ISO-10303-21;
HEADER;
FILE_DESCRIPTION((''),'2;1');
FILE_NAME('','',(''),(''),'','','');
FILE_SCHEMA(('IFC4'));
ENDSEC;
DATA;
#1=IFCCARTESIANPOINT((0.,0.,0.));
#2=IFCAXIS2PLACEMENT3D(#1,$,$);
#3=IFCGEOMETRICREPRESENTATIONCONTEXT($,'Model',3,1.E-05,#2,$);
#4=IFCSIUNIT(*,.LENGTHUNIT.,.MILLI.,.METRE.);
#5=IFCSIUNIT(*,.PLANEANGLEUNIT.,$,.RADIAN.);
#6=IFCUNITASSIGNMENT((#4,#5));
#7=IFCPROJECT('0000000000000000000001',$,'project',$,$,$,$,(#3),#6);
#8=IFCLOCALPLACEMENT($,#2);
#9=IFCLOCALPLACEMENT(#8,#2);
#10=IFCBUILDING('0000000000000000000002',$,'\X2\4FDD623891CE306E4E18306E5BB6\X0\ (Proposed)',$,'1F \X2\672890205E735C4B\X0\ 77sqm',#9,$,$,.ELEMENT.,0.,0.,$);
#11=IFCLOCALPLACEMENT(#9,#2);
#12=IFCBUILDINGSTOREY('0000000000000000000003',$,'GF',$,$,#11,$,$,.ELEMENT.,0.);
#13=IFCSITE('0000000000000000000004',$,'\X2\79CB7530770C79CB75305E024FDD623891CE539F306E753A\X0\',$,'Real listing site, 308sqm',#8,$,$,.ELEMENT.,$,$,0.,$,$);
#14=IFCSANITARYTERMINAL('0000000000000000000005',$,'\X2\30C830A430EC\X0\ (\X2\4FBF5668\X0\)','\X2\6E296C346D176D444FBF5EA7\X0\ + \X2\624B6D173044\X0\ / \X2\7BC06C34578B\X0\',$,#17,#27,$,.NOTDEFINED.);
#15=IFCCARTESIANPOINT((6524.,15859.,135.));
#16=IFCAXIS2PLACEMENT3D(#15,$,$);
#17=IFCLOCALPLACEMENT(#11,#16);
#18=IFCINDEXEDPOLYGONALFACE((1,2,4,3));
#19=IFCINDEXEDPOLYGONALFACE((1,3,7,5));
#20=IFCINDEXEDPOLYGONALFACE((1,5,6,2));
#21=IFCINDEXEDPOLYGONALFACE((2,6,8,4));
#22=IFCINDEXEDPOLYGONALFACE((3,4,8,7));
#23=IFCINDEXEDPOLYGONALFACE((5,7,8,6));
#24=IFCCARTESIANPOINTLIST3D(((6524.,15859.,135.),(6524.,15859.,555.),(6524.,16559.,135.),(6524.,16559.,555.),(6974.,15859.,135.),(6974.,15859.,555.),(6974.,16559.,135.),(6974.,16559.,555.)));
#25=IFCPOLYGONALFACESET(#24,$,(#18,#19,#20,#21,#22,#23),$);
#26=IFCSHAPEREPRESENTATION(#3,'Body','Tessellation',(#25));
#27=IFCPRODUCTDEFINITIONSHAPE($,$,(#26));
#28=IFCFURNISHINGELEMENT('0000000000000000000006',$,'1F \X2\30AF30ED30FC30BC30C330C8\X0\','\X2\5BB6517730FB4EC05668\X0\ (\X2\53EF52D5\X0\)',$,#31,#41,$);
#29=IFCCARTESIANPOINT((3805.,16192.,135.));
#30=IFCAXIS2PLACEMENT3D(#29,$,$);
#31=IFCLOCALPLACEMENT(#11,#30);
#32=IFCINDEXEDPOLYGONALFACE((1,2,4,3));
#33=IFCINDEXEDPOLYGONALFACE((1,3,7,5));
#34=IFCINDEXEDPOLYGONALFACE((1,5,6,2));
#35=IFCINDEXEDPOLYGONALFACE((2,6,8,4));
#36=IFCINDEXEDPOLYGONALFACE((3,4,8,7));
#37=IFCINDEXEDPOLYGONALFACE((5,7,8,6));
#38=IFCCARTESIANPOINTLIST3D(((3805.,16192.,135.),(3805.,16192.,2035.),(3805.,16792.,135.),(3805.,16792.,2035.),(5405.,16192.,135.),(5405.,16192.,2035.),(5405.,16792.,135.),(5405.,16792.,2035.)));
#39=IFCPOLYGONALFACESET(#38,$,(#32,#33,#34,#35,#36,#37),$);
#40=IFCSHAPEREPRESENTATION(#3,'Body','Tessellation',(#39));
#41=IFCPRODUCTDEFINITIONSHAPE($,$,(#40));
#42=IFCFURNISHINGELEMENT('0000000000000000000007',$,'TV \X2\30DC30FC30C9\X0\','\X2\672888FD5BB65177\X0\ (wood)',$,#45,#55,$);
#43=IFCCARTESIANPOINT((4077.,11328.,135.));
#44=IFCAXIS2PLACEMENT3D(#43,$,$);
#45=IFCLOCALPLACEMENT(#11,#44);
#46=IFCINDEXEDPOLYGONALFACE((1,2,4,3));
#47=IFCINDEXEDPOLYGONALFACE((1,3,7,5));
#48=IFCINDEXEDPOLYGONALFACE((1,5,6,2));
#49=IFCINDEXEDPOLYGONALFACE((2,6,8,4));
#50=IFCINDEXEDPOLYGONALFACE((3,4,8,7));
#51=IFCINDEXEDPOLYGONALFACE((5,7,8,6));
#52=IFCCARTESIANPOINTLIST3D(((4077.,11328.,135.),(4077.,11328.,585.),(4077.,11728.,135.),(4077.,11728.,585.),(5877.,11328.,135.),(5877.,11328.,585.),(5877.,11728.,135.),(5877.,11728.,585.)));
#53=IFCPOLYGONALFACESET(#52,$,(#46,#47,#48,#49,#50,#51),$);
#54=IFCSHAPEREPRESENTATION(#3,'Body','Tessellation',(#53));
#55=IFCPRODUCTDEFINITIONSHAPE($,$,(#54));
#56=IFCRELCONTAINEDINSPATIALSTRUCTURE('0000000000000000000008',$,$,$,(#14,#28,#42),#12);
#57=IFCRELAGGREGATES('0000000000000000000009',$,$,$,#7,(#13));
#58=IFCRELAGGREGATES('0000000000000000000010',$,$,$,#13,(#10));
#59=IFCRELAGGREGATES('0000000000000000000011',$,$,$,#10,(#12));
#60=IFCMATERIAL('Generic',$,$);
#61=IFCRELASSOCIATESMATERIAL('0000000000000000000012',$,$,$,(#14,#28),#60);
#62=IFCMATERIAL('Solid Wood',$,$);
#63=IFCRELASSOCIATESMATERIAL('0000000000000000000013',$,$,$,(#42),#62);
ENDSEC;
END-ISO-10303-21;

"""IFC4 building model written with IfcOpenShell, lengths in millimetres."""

from ifc_helpers import new_model, si_unit, frame, frame_2d, origin, place, context, project, spatial, rectangle, extrude, material, element, save


model = new_model("IFC4")

# Units and contexts
model_context = context("Model", 3, precision=1e-05, world=origin())
ifc_project = project(units=[si_unit("LENGTHUNIT", "METRE", prefix="MILLI"), si_unit("PLANEANGLEUNIT", "RADIAN")], contexts=[model_context])

# Site, building, storey
site_placement = place(None, origin())
site = spatial("IfcSite", under=ifc_project, at=site_placement, Name="秋田県秋田市保戸野原の町", ObjectType="Real listing site, 308sqm", CompositionType="ELEMENT", RefElevation=0.0)
building_placement = place(site_placement, origin())
building = spatial("IfcBuilding", under=site, at=building_placement, Name="保戸野の丘の家 (Proposed)", ObjectType="1F 木造平屋 77sqm", CompositionType="ELEMENT", ElevationOfRefHeight=0.0, ElevationOfTerrain=0.0)
storey_placement = place(building_placement, origin())
storey = spatial("IfcBuildingStorey", under=building, at=storey_placement, Name="GF", CompositionType="ELEMENT", Elevation=0.0)

# Shared definitions
ifc_material_1 = material(Name="Solid Wood")

# Shared definitions
ifc_material_2 = material(Name="Generic")

# Sanitary terminal
sanitary_terminal_1_placement = place(storey_placement, frame((6524.0, 15859.0, 135.0)))
element("IfcSanitaryTerminal", 1, at=sanitary_terminal_1_placement, inside=storey, material=ifc_material_2, Name="トイレ (便器)", Description="温水洗浄便座 + 手洗い / 節水型", PredefinedType="NOTDEFINED", context=model_context, shape_type="SweptSolid", body=[
    extrude(rectangle(XDim=450.0, YDim=700.0, at=frame_2d((225.0, 350.0))), frame((6524.0, 15859.0, 135.0)), (0.0, 0.0, 1.0), 420.0),
])

# Furnishing elements
furnishing_1_placement = place(storey_placement, frame((3805.0, 16192.0, 135.0)))
element("IfcFurnishingElement", 2, at=furnishing_1_placement, inside=storey, material=ifc_material_2, Name="1F クローゼット", Description="家具・什器 (可動)", context=model_context, shape_type="SweptSolid", body=[
    extrude(rectangle(XDim=1600.0, YDim=600.0, at=frame_2d((800.0, 300.0))), frame((3805.0, 16192.0, 135.0)), (0.0, 0.0, 1.0), 1900.0),
])
furnishing_2_placement = place(storey_placement, frame((4077.0, 11328.0, 135.0)))
element("IfcFurnishingElement", 3, at=furnishing_2_placement, inside=storey, material=ifc_material_1, Name="TV ボード", Description="木製家具 (wood)", context=model_context, shape_type="SweptSolid", body=[
    extrude(rectangle(XDim=1800.0, YDim=400.0, at=frame_2d((900.0, 200.0))), frame((4077.0, 11328.0, 135.0)), (0.0, 0.0, 1.0), 450.0),
])

save(model, "model.ifc")
